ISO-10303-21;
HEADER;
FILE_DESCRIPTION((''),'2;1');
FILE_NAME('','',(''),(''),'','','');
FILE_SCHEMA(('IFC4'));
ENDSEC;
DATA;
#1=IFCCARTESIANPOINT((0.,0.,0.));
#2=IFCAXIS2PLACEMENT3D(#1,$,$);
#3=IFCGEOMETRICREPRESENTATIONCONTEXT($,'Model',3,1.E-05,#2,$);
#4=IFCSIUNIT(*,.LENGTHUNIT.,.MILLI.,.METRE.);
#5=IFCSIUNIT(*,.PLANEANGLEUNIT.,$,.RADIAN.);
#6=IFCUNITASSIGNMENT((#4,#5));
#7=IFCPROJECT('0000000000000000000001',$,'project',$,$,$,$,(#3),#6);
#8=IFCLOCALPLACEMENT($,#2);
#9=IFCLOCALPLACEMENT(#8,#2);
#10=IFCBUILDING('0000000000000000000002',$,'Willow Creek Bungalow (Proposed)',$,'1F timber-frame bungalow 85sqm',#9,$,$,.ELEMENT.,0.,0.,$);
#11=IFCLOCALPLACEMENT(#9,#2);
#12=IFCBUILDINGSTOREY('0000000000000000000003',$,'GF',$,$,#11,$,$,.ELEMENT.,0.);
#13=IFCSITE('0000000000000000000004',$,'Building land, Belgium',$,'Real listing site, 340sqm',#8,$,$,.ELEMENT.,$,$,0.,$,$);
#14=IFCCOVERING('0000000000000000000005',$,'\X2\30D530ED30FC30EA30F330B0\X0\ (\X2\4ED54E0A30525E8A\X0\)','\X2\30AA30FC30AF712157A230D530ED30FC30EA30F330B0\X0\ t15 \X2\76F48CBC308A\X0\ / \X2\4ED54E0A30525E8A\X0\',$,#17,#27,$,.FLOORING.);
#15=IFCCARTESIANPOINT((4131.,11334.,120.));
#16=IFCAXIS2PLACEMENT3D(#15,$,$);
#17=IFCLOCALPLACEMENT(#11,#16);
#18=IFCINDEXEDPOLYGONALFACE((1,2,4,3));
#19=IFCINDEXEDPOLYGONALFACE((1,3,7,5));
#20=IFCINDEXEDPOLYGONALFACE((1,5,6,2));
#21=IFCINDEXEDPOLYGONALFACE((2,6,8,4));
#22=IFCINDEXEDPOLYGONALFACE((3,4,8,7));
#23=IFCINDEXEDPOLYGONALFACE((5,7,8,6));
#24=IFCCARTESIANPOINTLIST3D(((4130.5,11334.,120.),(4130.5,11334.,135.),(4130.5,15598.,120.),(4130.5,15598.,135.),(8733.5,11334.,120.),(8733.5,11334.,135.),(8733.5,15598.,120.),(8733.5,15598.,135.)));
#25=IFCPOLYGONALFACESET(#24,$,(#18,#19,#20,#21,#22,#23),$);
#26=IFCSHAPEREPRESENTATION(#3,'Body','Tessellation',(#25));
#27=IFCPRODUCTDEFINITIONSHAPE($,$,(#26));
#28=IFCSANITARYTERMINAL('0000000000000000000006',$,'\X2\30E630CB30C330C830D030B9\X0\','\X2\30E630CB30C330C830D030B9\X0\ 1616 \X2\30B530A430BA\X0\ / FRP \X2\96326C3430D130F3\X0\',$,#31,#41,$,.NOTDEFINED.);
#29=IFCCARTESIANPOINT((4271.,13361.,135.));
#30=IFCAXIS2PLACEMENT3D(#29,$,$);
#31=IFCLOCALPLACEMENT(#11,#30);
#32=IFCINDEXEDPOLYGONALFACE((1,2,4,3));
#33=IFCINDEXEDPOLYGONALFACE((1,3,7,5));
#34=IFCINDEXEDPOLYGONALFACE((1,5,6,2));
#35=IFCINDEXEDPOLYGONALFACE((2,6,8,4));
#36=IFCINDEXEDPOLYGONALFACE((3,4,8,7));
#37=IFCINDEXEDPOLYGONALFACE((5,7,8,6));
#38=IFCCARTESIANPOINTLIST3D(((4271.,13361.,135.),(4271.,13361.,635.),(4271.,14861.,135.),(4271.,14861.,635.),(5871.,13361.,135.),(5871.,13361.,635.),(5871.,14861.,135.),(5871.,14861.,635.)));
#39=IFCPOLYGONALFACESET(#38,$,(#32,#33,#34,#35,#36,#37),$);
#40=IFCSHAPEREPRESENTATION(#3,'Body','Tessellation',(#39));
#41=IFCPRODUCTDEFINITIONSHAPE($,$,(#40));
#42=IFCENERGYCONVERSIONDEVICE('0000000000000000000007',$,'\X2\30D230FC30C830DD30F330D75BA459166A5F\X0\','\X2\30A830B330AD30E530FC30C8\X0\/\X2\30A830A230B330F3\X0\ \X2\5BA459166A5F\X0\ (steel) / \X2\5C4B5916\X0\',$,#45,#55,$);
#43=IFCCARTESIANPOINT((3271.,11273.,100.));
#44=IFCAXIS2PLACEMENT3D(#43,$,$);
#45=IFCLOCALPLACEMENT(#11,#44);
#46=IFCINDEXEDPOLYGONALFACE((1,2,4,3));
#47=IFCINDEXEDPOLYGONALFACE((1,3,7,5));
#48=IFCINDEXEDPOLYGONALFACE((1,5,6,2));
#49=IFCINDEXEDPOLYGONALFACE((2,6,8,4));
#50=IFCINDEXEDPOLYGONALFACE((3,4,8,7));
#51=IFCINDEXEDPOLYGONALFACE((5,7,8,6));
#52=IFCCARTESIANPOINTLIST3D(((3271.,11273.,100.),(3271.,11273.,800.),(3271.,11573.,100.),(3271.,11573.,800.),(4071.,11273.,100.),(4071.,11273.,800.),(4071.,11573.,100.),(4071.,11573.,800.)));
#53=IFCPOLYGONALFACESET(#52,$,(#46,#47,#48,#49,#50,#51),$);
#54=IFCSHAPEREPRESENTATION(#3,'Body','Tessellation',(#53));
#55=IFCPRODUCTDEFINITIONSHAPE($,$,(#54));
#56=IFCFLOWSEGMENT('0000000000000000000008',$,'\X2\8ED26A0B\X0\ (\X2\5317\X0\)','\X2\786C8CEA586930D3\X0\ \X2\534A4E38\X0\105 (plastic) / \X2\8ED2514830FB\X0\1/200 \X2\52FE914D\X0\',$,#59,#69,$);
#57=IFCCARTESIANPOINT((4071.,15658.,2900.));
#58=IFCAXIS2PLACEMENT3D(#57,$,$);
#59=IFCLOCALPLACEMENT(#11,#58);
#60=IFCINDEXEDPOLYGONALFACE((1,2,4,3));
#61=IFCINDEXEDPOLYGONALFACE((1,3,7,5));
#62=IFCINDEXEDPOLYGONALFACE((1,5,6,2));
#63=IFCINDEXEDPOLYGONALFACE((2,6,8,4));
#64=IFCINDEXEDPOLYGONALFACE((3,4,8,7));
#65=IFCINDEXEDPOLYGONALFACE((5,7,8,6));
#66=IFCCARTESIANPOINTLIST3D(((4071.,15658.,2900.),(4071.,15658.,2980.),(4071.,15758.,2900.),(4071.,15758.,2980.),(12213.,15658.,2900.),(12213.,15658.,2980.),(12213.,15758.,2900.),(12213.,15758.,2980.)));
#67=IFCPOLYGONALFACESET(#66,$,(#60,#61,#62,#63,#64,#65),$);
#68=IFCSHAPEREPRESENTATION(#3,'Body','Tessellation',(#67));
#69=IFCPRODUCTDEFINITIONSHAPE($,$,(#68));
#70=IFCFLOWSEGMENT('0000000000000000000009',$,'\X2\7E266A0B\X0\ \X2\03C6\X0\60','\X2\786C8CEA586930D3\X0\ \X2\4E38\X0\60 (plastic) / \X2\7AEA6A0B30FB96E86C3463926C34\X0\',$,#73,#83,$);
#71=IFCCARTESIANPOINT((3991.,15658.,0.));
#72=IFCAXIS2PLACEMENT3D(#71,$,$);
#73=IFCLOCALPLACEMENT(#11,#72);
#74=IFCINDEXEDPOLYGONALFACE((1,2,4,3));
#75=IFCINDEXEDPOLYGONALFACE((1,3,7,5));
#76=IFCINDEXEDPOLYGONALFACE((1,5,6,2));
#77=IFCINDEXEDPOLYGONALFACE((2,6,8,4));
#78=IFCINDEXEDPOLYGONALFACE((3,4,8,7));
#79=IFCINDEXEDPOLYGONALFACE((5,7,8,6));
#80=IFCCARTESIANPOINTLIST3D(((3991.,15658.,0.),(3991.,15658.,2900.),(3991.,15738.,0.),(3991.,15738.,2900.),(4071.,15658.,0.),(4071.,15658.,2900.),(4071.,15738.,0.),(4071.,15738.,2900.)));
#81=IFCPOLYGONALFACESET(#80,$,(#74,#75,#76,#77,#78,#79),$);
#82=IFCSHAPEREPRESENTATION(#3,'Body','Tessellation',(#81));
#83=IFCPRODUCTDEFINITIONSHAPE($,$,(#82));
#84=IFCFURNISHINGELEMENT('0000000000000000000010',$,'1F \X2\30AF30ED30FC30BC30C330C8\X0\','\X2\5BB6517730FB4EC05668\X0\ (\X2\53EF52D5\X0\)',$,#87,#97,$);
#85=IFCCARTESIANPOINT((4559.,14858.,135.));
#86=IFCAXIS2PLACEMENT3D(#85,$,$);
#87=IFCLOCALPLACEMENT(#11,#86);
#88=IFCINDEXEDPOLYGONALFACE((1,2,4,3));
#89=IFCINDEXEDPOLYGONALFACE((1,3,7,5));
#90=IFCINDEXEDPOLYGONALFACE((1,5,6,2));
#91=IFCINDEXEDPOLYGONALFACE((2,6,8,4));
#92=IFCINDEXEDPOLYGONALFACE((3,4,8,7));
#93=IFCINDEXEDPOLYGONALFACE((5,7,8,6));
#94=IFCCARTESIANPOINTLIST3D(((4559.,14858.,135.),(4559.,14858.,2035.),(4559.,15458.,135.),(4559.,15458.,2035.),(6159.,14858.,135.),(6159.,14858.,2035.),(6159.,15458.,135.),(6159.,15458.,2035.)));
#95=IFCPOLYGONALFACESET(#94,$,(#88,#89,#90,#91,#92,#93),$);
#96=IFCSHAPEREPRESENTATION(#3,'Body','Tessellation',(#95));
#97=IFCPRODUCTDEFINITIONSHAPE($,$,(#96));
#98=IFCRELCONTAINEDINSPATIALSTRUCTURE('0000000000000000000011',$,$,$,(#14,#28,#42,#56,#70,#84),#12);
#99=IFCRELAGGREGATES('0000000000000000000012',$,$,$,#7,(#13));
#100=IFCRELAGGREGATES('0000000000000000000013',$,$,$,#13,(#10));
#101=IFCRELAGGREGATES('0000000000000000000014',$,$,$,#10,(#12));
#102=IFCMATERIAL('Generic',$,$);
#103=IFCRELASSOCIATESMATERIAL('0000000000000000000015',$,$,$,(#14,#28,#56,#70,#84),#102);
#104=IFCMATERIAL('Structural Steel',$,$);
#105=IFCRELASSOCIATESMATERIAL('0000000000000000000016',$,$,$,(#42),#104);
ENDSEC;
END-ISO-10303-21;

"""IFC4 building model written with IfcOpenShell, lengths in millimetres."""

from ifc_helpers import new_model, si_unit, frame, frame_2d, origin, place, context, project, spatial, rectangle, extrude, material, element, save


model = new_model("IFC4")

# Units and contexts
model_context = context("Model", 3, precision=1e-05, world=origin())
ifc_project = project(units=[si_unit("LENGTHUNIT", "METRE", prefix="MILLI"), si_unit("PLANEANGLEUNIT", "RADIAN")], contexts=[model_context])

# Site, building, storey
site_placement = place(None, origin())
site = spatial("IfcSite", under=ifc_project, at=site_placement, Name="Building land, Belgium", ObjectType="Real listing site, 340sqm", CompositionType="ELEMENT", RefElevation=0.0)
building_placement = place(site_placement, origin())
building = spatial("IfcBuilding", under=site, at=building_placement, Name="Willow Creek Bungalow (Proposed)", ObjectType="1F timber-frame bungalow 85sqm", CompositionType="ELEMENT", ElevationOfRefHeight=0.0, ElevationOfTerrain=0.0)
storey_placement = place(building_placement, origin())
storey = spatial("IfcBuildingStorey", under=building, at=storey_placement, Name="GF", CompositionType="ELEMENT", Elevation=0.0)

# Shared definitions
ifc_material_1 = material(Name="Structural Steel")

# Covering
ifc_material_2 = material(Name="Generic")
covering_placement = place(storey_placement, frame((4131.0, 11334.0, 120.0)))
element("IfcCovering", 1, at=covering_placement, inside=storey, material=ifc_material_2, Name="フローリング (仕上げ床)", Description="オーク無垢フローリング t15 直貼り / 仕上げ床", PredefinedType="FLOORING", context=model_context, shape_type="SweptSolid", body=[
    extrude(rectangle(XDim=4603.0, YDim=4264.0, at=frame_2d((2301.0, 2132.0))), frame((4131.0, 11334.0, 120.0)), (0.0, 0.0, 1.0), 15.0),
])

# Sanitary terminal
sanitary_terminal_placement = place(storey_placement, frame((4271.0, 13361.0, 135.0)))
element("IfcSanitaryTerminal", 2, at=sanitary_terminal_placement, inside=storey, material=ifc_material_2, Name="ユニットバス", Description="ユニットバス 1616 サイズ / FRP 防水パン", PredefinedType="NOTDEFINED", context=model_context, shape_type="SweptSolid", body=[
    extrude(rectangle(XDim=1600.0, YDim=1500.0, at=frame_2d((800.0, 750.0))), frame((4271.0, 13361.0, 135.0)), (0.0, 0.0, 1.0), 500.0),
])

# Energy conversion device
energy_conversion_device_placement = place(storey_placement, frame((3271.0, 11273.0, 100.0)))
element("IfcEnergyConversionDevice", 3, at=energy_conversion_device_placement, inside=storey, material=ifc_material_1, Name="ヒートポンプ室外機", Description="エコキュート/エアコン 室外機 (steel) / 屋外", context=model_context, shape_type="SweptSolid", body=[
    extrude(rectangle(XDim=800.0, YDim=300.0, at=frame_2d((400.0, 150.0))), frame((3271.0, 11273.0, 100.0)), (0.0, 0.0, 1.0), 700.0),
])

# Flow segments
flow_segment_1_placement = place(storey_placement, frame((4071.0, 15658.0, 2900.0)))
element("IfcFlowSegment", 4, at=flow_segment_1_placement, inside=storey, material=ifc_material_2, Name="軒樋 (北)", Description="硬質塩ビ 半丸105 (plastic) / 軒先・1/200 勾配", context=model_context, shape_type="SweptSolid", body=[
    extrude(rectangle(XDim=8142.0, YDim=100.0, at=frame_2d((4071.0, 50.0))), frame((4071.0, 15658.0, 2900.0)), (0.0, 0.0, 1.0), 80.0),
])
flow_segment_2_placement = place(storey_placement, frame((3991.0, 15658.0, 0.0)))
element("IfcFlowSegment", 5, at=flow_segment_2_placement, inside=storey, material=ifc_material_2, Name="縦樋 φ60", Description="硬質塩ビ 丸60 (plastic) / 竪樋・雨水排水", context=model_context, shape_type="SweptSolid", body=[
    extrude(rectangle(XDim=80.0, YDim=80.0, at=frame_2d((40.0, 40.0))), frame((3991.0, 15658.0, 0.0)), (0.0, 0.0, 1.0), 2900.0),
])

# Furnishing element
furnishing_placement = place(storey_placement, frame((4559.0, 14858.0, 135.0)))
element("IfcFurnishingElement", 6, at=furnishing_placement, inside=storey, material=ifc_material_2, Name="1F クローゼット", Description="家具・什器 (可動)", context=model_context, shape_type="SweptSolid", body=[
    extrude(rectangle(XDim=1600.0, YDim=600.0, at=frame_2d((800.0, 300.0))), frame((4559.0, 14858.0, 135.0)), (0.0, 0.0, 1.0), 1900.0),
])

save(model, "model.ifc")
